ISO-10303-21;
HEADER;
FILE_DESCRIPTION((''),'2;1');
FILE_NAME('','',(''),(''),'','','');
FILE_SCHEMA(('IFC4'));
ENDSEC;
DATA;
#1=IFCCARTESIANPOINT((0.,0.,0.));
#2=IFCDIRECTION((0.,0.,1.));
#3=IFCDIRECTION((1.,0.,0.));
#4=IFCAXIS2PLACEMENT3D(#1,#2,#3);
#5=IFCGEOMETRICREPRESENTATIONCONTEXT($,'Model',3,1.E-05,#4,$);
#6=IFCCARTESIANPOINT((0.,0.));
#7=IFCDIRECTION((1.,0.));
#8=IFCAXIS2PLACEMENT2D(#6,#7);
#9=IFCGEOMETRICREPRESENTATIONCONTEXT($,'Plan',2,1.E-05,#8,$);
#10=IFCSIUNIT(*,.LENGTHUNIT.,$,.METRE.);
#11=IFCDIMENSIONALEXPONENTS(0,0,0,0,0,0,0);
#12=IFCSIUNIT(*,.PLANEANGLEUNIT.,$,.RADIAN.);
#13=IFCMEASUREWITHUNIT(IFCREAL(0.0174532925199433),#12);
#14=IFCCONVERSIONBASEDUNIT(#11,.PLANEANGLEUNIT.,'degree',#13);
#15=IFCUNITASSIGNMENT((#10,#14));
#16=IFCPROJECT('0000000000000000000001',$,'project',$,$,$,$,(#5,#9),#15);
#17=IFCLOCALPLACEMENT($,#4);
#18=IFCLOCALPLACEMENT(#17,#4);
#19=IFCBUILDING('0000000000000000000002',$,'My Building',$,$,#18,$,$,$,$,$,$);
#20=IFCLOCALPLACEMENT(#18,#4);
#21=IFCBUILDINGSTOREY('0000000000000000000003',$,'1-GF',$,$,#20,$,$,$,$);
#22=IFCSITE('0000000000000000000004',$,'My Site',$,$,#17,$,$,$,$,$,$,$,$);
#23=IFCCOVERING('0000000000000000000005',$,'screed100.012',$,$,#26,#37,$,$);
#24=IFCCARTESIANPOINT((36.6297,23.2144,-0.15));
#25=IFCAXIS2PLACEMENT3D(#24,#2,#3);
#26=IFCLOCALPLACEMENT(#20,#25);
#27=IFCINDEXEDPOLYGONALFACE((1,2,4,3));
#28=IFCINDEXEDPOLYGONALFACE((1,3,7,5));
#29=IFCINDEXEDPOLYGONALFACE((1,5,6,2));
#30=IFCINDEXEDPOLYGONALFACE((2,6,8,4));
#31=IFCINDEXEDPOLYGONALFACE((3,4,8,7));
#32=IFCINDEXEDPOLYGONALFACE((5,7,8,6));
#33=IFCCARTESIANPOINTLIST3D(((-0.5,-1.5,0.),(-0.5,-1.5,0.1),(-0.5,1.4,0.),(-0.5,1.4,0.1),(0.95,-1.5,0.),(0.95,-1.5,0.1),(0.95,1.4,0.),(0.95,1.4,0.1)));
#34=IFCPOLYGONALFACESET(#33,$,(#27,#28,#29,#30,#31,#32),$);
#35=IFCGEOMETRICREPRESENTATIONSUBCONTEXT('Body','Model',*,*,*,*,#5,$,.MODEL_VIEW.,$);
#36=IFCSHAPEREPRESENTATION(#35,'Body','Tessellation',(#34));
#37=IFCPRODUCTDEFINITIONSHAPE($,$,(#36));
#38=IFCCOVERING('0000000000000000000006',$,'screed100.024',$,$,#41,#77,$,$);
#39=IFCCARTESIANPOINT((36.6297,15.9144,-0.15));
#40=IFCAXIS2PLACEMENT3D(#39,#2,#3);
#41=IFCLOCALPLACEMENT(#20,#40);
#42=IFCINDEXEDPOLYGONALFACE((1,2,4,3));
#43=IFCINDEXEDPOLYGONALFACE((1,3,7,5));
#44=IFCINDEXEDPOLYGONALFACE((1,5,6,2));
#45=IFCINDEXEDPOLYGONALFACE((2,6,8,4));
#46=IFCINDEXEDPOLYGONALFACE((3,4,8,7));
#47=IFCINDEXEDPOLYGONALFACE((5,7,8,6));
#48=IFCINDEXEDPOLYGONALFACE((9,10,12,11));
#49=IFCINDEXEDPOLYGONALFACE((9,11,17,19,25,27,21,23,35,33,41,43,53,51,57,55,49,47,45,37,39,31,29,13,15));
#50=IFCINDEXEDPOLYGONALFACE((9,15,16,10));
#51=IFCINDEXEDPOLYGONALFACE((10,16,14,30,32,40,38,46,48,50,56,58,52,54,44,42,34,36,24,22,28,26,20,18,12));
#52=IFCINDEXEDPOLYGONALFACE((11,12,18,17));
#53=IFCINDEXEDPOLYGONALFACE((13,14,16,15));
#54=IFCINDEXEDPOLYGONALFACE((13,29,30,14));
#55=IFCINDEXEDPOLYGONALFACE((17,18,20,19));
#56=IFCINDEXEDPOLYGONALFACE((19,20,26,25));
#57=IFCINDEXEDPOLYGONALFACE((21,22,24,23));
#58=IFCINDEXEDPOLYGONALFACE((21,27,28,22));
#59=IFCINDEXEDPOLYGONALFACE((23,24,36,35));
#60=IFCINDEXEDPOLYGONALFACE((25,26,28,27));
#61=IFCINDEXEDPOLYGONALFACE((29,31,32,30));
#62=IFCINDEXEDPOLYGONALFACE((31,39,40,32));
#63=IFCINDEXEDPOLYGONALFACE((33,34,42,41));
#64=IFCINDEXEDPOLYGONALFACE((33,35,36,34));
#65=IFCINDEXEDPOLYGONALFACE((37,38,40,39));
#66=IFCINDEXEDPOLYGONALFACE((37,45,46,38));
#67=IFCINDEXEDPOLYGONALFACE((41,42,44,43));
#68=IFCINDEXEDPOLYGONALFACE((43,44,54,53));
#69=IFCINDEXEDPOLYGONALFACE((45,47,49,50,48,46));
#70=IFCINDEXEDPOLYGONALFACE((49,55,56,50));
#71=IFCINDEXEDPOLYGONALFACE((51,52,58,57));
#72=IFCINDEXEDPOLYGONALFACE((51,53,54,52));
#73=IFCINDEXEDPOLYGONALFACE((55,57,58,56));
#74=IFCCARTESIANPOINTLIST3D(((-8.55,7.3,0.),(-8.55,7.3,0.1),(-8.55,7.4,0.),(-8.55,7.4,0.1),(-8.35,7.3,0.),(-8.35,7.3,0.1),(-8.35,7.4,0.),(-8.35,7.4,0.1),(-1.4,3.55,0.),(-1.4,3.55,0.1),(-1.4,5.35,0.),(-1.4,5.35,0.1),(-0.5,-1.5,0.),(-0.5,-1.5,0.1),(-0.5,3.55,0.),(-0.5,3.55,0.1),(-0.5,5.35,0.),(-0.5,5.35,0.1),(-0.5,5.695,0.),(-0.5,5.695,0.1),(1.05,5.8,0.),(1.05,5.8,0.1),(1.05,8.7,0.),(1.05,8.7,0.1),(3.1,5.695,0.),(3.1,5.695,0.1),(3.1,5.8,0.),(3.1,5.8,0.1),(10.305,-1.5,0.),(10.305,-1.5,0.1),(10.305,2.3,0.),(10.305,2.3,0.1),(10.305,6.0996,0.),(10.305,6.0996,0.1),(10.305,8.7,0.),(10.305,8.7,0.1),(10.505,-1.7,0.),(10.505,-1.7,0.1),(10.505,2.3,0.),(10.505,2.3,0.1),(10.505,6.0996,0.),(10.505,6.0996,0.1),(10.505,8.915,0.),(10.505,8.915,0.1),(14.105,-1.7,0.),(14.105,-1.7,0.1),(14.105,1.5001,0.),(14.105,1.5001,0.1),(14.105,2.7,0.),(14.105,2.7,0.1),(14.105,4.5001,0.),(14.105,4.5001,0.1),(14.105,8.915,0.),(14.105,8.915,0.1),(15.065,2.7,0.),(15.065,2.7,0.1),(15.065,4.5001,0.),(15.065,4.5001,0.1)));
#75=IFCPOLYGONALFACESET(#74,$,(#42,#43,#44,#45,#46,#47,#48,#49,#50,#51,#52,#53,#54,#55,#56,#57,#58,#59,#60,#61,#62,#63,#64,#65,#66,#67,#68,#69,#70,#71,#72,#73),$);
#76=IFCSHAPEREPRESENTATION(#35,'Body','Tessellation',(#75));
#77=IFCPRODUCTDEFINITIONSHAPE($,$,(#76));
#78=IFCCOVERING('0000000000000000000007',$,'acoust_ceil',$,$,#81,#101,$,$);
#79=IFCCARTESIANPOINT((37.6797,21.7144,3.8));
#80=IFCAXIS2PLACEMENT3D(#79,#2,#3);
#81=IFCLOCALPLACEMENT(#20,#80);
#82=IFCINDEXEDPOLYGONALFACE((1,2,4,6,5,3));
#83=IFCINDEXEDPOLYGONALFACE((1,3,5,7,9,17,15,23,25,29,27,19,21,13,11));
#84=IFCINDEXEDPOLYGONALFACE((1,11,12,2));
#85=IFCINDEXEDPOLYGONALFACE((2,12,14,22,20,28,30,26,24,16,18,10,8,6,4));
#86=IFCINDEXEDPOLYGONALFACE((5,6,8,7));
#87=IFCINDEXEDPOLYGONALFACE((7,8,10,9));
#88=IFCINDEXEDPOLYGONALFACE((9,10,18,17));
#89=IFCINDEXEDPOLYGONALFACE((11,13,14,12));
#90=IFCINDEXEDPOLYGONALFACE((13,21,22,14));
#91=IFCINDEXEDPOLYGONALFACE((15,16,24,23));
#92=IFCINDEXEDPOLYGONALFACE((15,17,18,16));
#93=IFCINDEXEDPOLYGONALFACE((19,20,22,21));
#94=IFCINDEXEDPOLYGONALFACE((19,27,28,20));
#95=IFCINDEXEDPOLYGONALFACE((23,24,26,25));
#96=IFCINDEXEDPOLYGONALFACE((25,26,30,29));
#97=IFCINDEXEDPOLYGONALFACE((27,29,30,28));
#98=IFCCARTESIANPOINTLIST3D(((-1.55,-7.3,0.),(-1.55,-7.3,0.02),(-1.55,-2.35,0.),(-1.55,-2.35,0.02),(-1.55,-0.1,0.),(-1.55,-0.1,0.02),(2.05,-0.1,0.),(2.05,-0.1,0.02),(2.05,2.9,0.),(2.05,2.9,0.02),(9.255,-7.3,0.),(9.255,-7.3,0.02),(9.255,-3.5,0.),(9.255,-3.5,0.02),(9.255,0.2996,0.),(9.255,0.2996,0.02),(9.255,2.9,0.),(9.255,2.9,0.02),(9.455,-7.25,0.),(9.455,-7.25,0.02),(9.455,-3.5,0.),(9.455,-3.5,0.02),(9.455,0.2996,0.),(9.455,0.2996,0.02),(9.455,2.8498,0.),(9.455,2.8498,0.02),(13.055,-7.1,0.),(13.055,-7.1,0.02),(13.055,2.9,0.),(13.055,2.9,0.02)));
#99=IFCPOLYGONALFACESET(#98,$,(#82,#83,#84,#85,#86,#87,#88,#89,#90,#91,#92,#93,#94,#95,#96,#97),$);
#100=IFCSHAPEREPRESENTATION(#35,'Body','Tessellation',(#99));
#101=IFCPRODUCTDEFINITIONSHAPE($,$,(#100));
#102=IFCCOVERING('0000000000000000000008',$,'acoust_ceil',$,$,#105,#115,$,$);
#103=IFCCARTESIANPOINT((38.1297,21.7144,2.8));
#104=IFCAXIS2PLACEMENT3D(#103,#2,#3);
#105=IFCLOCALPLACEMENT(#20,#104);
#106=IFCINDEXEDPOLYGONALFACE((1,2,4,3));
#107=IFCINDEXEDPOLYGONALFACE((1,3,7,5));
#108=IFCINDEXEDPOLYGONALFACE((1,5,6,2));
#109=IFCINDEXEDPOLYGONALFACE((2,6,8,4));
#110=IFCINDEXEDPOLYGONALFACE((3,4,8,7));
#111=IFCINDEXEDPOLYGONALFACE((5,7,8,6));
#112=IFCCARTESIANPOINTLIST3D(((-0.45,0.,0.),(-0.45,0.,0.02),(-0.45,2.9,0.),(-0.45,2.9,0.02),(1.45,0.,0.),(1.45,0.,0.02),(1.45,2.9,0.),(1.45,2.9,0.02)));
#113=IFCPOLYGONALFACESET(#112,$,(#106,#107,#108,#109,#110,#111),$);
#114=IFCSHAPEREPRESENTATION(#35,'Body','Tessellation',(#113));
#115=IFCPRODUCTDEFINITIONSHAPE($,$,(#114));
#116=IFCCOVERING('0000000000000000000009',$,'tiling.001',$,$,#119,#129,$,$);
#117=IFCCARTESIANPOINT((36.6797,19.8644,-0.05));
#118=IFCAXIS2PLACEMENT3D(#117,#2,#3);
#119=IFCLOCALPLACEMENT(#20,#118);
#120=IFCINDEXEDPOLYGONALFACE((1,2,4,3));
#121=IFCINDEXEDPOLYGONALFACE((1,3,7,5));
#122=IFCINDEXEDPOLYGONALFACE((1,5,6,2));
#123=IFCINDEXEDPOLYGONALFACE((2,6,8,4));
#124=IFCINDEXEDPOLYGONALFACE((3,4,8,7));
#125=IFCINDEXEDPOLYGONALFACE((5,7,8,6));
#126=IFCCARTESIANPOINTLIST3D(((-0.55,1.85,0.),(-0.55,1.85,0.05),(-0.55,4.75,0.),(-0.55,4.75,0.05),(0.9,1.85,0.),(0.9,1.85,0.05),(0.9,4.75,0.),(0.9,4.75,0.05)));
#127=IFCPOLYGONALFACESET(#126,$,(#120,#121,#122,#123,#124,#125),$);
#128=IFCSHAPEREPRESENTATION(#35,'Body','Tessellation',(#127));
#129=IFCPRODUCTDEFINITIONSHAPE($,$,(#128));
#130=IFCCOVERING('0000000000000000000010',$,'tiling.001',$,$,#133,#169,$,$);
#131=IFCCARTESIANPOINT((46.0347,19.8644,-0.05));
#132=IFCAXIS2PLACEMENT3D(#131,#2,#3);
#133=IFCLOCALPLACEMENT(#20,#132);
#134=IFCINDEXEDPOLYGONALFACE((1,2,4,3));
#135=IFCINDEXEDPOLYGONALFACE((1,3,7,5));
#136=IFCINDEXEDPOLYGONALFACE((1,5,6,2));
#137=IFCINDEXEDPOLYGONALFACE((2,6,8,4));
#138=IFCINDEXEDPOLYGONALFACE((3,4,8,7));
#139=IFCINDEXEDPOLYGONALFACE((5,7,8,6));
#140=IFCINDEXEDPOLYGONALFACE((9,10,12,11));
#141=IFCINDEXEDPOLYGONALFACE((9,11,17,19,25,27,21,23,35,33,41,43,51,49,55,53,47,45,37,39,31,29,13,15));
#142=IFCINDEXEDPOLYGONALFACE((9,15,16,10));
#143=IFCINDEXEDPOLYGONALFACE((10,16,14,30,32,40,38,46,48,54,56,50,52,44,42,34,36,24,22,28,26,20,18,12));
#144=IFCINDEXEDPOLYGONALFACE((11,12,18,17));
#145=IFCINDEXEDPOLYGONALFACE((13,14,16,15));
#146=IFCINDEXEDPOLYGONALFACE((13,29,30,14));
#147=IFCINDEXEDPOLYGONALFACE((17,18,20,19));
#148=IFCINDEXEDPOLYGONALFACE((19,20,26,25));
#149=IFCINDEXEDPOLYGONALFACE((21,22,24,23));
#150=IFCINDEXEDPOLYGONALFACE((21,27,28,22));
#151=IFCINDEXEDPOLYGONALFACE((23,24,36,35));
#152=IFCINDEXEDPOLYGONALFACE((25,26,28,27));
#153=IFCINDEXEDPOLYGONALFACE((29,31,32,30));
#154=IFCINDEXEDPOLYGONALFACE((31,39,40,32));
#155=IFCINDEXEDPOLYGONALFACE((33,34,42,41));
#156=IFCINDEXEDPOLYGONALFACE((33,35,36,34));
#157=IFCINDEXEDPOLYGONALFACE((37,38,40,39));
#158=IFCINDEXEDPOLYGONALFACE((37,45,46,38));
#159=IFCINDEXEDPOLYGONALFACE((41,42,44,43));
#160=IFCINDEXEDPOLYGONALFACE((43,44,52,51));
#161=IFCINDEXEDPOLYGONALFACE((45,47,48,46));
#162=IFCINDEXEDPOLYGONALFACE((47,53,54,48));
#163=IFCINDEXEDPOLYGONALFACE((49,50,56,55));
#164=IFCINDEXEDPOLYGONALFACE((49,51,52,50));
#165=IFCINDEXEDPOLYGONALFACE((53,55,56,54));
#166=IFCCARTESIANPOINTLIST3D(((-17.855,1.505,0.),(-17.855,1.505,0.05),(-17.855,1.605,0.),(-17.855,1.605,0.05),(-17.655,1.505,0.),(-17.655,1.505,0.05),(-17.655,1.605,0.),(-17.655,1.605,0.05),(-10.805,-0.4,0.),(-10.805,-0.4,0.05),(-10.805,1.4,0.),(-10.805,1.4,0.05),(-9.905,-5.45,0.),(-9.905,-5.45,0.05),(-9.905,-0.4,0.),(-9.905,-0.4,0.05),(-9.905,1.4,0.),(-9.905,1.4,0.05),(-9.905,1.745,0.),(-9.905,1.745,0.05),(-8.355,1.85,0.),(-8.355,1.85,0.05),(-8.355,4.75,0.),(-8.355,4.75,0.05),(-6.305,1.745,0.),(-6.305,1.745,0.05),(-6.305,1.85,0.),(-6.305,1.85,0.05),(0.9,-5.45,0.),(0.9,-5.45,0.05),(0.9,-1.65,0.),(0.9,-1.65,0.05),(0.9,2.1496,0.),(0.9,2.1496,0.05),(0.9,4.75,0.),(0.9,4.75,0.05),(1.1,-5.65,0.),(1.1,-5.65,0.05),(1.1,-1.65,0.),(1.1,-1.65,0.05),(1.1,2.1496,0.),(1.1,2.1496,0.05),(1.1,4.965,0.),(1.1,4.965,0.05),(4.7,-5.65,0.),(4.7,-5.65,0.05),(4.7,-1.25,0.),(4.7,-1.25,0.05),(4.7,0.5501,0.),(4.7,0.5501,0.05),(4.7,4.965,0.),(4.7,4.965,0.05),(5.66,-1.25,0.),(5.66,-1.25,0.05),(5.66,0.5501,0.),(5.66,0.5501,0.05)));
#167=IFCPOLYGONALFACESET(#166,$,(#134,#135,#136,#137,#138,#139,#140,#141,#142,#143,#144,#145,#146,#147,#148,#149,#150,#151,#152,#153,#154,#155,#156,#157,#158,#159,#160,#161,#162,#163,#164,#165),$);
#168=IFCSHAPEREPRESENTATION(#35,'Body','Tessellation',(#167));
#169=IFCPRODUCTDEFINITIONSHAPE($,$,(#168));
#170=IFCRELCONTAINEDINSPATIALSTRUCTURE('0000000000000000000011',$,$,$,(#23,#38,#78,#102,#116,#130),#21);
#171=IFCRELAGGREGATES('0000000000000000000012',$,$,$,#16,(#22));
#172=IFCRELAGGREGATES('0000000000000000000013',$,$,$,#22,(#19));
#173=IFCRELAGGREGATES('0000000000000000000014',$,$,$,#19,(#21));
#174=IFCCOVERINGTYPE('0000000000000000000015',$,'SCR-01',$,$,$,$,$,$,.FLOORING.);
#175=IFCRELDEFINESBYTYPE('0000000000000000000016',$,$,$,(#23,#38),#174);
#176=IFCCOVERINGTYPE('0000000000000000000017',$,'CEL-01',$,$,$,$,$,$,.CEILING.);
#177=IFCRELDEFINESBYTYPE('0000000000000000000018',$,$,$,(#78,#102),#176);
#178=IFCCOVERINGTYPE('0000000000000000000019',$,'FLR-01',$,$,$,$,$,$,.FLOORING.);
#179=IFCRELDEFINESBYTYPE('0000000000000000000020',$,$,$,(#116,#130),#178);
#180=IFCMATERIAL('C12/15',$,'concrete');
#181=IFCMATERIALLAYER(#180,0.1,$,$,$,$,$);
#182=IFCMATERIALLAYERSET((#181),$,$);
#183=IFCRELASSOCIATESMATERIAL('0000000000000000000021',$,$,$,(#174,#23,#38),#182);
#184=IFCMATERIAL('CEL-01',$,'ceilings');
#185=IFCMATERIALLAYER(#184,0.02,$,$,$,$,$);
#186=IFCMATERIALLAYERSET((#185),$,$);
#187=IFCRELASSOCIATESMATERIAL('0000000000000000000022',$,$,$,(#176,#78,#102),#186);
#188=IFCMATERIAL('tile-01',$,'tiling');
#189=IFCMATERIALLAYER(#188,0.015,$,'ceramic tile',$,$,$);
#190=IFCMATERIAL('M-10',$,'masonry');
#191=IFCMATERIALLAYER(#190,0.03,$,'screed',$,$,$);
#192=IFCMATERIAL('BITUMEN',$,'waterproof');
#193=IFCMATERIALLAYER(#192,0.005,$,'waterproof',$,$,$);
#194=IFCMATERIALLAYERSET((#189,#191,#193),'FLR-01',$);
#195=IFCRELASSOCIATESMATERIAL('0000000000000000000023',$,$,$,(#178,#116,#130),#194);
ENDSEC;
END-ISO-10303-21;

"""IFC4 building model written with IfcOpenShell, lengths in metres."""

from ifc_helpers import new_model, entity, si_unit, converted_unit, frame, origin_with_axes, origin_2d_with_axis, place, context, subcontext, project, spatial, line, indexed_curve, outline, extrude, material, layer, layer_set, layer_usage, type_object, element, save


model = new_model("IFC4")

# Units and contexts
model_context = context("Model", 3, precision=1e-05, world=origin_with_axes())
plan_context = context("Plan", 2, precision=1e-05, world=origin_2d_with_axis())
body_context_1 = subcontext(model_context, "Body", "Model", "MODEL_VIEW")
ifc_project = project(units=[si_unit("LENGTHUNIT", "METRE"), converted_unit("PLANEANGLEUNIT", "degree", entity("IfcReal", 0.0174532925199433), si_unit("PLANEANGLEUNIT", "RADIAN"), dimensions=[0, 0, 0, 0, 0, 0, 0])], contexts=[model_context, plan_context])

# Site, building, storey
site_placement = place(None, origin_with_axes())
site = spatial("IfcSite", under=ifc_project, at=site_placement, Name="My Site")
building_placement = place(site_placement, origin_with_axes())
building = spatial("IfcBuilding", under=site, at=building_placement, Name="My Building")
storey_placement = place(building_placement, origin_with_axes())
storey = spatial("IfcBuildingStorey", under=building, at=storey_placement, Name="1-GF")

# Coverings
ifc_material_1 = material(Name="C12/15", Category="concrete")
ifc_layer_1 = layer(ifc_material_1, 0.1)
ifc_layer_set_1 = layer_set([ifc_layer_1])
ifc_layer_usage_1 = layer_usage(ifc_layer_set_1, "AXIS3", "POSITIVE", 0.0)
covering_type_1 = type_object("IfcCoveringType", Name="SCR-01", PredefinedType="FLOORING", material=ifc_layer_set_1)
covering_1_placement = place(storey_placement, frame((36.6297, 23.2144, -0.15), z_axis=(0.0, 0.0, 1.0), x_axis=(1.0, 0.0, 0.0)))
element("IfcCovering", 1, at=covering_1_placement, inside=storey, type_object=covering_type_1, material=ifc_layer_usage_1, Name="screed100.012", context=body_context_1, shape_type="SweptSolid", body=[
    extrude(outline(indexed_curve([(-0.5, 1.4), (-0.5, -1.5), (0.95, -1.5), (0.95, 1.4)], segments=[line(3, 2), line(2, 1), line(1, 4), line(4, 3)], self_intersect=False)), None, (0.0, 0.0, 1.0), 0.1),
])
ifc_layer_usage_2 = layer_usage(ifc_layer_set_1, "AXIS3", "POSITIVE", 0.0)
covering_2_placement = place(storey_placement, frame((36.6297, 15.9144, -0.15), z_axis=(0.0, 0.0, 1.0), x_axis=(1.0, 0.0, 0.0)))
element("IfcCovering", 2, at=covering_2_placement, inside=storey, type_object=covering_type_1, material=ifc_layer_usage_2, Name="screed100.024", context=body_context_1, shape_type="SweptSolid", body=[
    extrude(outline(indexed_curve([(10.505, -1.7), (14.105, -1.7), (14.105, 1.5001), (14.105, 2.7), (15.065, 2.7), (15.065, 4.5001), (14.105, 4.5001), (14.105, 8.915), (10.505, 8.915), (10.505, 6.0996), (10.305, 6.0996), (10.305, 8.7), (1.05, 8.7), (1.05, 5.8), (3.1, 5.8), (3.1, 5.695), (-0.5, 5.695), (-0.5, 5.35), (-1.4, 5.35), (-1.4, 3.55), (-0.5, 3.55), (-0.5, -1.5), (10.305, -1.5), (10.305, 2.3), (10.505, 2.3), (-8.35, 7.4), (-8.35, 7.3), (-8.55, 7.3), (-8.55, 7.4)], segments=[line(10, 9), line(9, 8), line(8, 7), line(7, 6), line(6, 5), line(5, 4), line(4, 3), line(3, 2), line(2, 1), line(1, 25), line(25, 24), line(24, 23), line(23, 22), line(22, 21), line(21, 20), line(20, 19), line(19, 18), line(18, 17), line(17, 16), line(16, 15), line(15, 14), line(14, 13), line(13, 12), line(12, 11), line(11, 10)], self_intersect=False), holes=[indexed_curve([(10.505, -1.7), (14.105, -1.7), (14.105, 1.5001), (14.105, 2.7), (15.065, 2.7), (15.065, 4.5001), (14.105, 4.5001), (14.105, 8.915), (10.505, 8.915), (10.505, 6.0996), (10.305, 6.0996), (10.305, 8.7), (1.05, 8.7), (1.05, 5.8), (3.1, 5.8), (3.1, 5.695), (-0.5, 5.695), (-0.5, 5.35), (-1.4, 5.35), (-1.4, 3.55), (-0.5, 3.55), (-0.5, -1.5), (10.305, -1.5), (10.305, 2.3), (10.505, 2.3), (-8.35, 7.4), (-8.35, 7.3), (-8.55, 7.3), (-8.55, 7.4)], segments=[line(29, 28), line(28, 27), line(27, 26), line(26, 29)], self_intersect=False)]), None, (0.0, 0.0, 1.0), 0.1),
])
ifc_material_2 = material(Name="CEL-01", Category="ceilings")
ifc_layer_2 = layer(ifc_material_2, 0.02)
ifc_layer_set_2 = layer_set([ifc_layer_2])
covering_type_2 = type_object("IfcCoveringType", Name="CEL-01", PredefinedType="CEILING", material=ifc_layer_set_2)
ifc_layer_usage_3 = layer_usage(ifc_layer_set_2, "AXIS3", "POSITIVE", 0.0)
covering_3_placement = place(storey_placement, frame((37.6797, 21.7144, 3.8), z_axis=(0.0, 0.0, 1.0), x_axis=(1.0, 0.0, 0.0)))
element("IfcCovering", 3, at=covering_3_placement, inside=storey, type_object=covering_type_2, material=ifc_layer_usage_3, Name="acoust_ceil", context=body_context_1, shape_type="SweptSolid", body=[
    extrude(outline(indexed_curve([(9.255, -3.5), (9.455, -3.5), (9.455, -7.25), (13.055, -7.1), (13.055, 2.9), (9.455, 2.8498), (9.455, 0.2996), (9.255, 0.2996), (9.255, 2.9), (2.05, 2.9), (2.05, -0.1), (-1.55, -0.1), (-1.55, -2.35), (-1.55, -7.3), (9.255, -7.3)], segments=[line(4, 3), line(3, 2), line(2, 1), line(1, 15), line(15, 14), line(14, 13), line(13, 12), line(12, 11), line(11, 10), line(10, 9), line(9, 8), line(8, 7), line(7, 6), line(6, 5), line(5, 4)], self_intersect=False)), None, (0.0, 0.0, 1.0), 0.02),
])
ifc_layer_usage_4 = layer_usage(ifc_layer_set_2, "AXIS3", "POSITIVE", 0.0)
covering_4_placement = place(storey_placement, frame((38.1297, 21.7144, 2.8), z_axis=(0.0, 0.0, 1.0), x_axis=(1.0, 0.0, 0.0)))
element("IfcCovering", 4, at=covering_4_placement, inside=storey, type_object=covering_type_2, material=ifc_layer_usage_4, Name="acoust_ceil", context=body_context_1, shape_type="SweptSolid", body=[
    extrude(outline(indexed_curve([(1.45, 2.9), (1.45, 0.0), (-0.45, 0.0), (-0.45, 2.9)], segments=[line(3, 2), line(2, 1), line(1, 4), line(4, 3)], self_intersect=False)), None, (0.0, 0.0, 1.0), 0.02),
])
ifc_material_3 = material(Name="tile-01", Category="tiling")
ifc_layer_3 = layer(ifc_material_3, 0.015, Name="ceramic tile")
ifc_material_4 = material(Name="M-10", Category="masonry")
ifc_layer_4 = layer(ifc_material_4, 0.03, Name="screed")
ifc_material_5 = material(Name="BITUMEN", Category="waterproof")
ifc_layer_5 = layer(ifc_material_5, 0.005, Name="waterproof")
ifc_layer_set_3 = layer_set([ifc_layer_3, ifc_layer_4, ifc_layer_5], Name="FLR-01")
ifc_layer_usage_5 = layer_usage(ifc_layer_set_3, "AXIS3", "POSITIVE", 0.0)
covering_type_3 = type_object("IfcCoveringType", Name="FLR-01", PredefinedType="FLOORING", material=ifc_layer_set_3)
covering_5_placement = place(storey_placement, frame((36.6797, 19.8644, -0.05), z_axis=(0.0, 0.0, 1.0), x_axis=(1.0, 0.0, 0.0)))
element("IfcCovering", 5, at=covering_5_placement, inside=storey, type_object=covering_type_3, material=ifc_layer_usage_5, Name="tiling.001", context=body_context_1, shape_type="SweptSolid", body=[
    extrude(outline(indexed_curve([(-0.55, 4.75), (0.9, 4.75), (0.9, 1.85), (-0.55, 1.85)], segments=[line(3, 2), line(2, 1), line(1, 4), line(4, 3)], self_intersect=False)), None, (0.0, 0.0, 1.0), 0.05),
])
ifc_layer_usage_6 = layer_usage(ifc_layer_set_3, "AXIS3", "POSITIVE", 0.0)
covering_6_placement = place(storey_placement, frame((46.0347, 19.8644, -0.05), z_axis=(0.0, 0.0, 1.0), x_axis=(1.0, 0.0, 0.0)))
element("IfcCovering", 6, at=covering_6_placement, inside=storey, type_object=covering_type_3, material=ifc_layer_usage_6, Name="tiling.001", context=body_context_1, shape_type="SweptSolid", body=[
    extrude(outline(indexed_curve([(-6.305, 1.745), (-6.305, 1.85), (-8.355, 1.85), (-8.355, 4.75), (0.9, 4.75), (0.9, 2.1496), (1.1, 2.1496), (1.1, 4.965), (4.7, 4.965), (4.7, 0.5501), (5.66, 0.5501), (5.66, -1.25), (4.7, -1.25), (4.7, -5.65), (1.1, -5.65), (1.1, -1.65), (0.9, -1.65), (0.9, -5.45), (-9.905, -5.45), (-9.905, -0.4), (-10.805, -0.4), (-10.805, 1.4), (-9.905, 1.4), (-9.905, 1.745), (-17.655, 1.605), (-17.855, 1.605), (-17.855, 1.505), (-17.655, 1.505)], segments=[line(8, 7), line(7, 6), line(6, 5), line(5, 4), line(4, 3), line(3, 2), line(2, 1), line(1, 24), line(24, 23), line(23, 22), line(22, 21), line(21, 20), line(20, 19), line(19, 18), line(18, 17), line(17, 16), line(16, 15), line(15, 14), line(14, 13), line(13, 12), line(12, 11), line(11, 10), line(10, 9), line(9, 8)], self_intersect=False), holes=[indexed_curve([(-6.305, 1.745), (-6.305, 1.85), (-8.355, 1.85), (-8.355, 4.75), (0.9, 4.75), (0.9, 2.1496), (1.1, 2.1496), (1.1, 4.965), (4.7, 4.965), (4.7, 0.5501), (5.66, 0.5501), (5.66, -1.25), (4.7, -1.25), (4.7, -5.65), (1.1, -5.65), (1.1, -1.65), (0.9, -1.65), (0.9, -5.45), (-9.905, -5.45), (-9.905, -0.4), (-10.805, -0.4), (-10.805, 1.4), (-9.905, 1.4), (-9.905, 1.745), (-17.655, 1.605), (-17.855, 1.605), (-17.855, 1.505), (-17.655, 1.505)], segments=[line(28, 27), line(27, 26), line(26, 25), line(25, 28)], self_intersect=False)]), None, (0.0, 0.0, 1.0), 0.05),
])

save(model, "model.ifc")
